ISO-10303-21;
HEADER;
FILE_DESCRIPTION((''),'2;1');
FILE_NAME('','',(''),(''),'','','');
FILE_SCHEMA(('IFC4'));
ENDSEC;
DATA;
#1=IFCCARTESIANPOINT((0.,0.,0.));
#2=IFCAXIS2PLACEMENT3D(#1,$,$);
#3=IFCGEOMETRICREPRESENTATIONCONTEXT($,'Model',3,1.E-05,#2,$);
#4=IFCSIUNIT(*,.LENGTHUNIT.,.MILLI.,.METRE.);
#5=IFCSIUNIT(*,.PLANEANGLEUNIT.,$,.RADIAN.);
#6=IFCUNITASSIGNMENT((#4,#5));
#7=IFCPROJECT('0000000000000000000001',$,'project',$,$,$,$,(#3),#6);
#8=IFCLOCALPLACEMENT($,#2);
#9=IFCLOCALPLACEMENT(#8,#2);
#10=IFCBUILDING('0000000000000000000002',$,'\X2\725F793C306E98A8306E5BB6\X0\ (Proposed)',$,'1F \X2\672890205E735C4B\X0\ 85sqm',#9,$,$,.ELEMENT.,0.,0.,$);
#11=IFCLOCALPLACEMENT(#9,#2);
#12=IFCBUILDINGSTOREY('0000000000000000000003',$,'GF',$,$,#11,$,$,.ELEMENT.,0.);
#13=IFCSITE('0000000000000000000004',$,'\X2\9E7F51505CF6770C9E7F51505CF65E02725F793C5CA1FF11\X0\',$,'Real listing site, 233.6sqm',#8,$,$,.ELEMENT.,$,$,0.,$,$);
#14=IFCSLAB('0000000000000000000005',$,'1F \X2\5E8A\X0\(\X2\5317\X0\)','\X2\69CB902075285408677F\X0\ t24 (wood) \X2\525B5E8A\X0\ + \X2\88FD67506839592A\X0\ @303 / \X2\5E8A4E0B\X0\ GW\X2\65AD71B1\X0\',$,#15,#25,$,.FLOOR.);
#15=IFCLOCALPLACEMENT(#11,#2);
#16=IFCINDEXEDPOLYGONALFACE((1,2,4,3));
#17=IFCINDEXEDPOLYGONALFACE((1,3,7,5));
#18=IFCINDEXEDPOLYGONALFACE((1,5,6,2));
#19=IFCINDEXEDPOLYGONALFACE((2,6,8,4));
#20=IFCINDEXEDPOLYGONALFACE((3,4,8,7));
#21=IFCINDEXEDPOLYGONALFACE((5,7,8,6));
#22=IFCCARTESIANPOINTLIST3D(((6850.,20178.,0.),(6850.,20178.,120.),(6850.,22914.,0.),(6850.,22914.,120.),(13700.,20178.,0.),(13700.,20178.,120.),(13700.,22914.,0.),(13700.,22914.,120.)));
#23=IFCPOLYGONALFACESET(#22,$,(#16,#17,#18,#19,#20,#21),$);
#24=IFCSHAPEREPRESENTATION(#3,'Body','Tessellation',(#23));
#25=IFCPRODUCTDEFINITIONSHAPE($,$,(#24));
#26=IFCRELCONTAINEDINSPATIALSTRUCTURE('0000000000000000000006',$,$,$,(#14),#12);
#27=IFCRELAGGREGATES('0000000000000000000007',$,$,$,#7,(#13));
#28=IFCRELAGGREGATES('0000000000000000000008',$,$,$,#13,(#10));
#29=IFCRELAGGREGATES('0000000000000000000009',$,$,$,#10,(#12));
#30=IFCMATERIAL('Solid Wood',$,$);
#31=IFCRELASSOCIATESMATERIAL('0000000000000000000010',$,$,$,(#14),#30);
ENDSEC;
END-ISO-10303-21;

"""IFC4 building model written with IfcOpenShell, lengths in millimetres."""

from ifc_helpers import new_model, si_unit, frame, frame_2d, origin, place, context, project, spatial, rectangle, extrude, material, element, save


model = new_model("IFC4")

# Units and contexts
model_context = context("Model", 3, precision=1e-05, world=origin())
ifc_project = project(units=[si_unit("LENGTHUNIT", "METRE", prefix="MILLI"), si_unit("PLANEANGLEUNIT", "RADIAN")], contexts=[model_context])

# Site, building, storey
site_placement = place(None, origin())
site = spatial("IfcSite", under=ifc_project, at=site_placement, Name="鹿児島県鹿児島市牟礼岡１", ObjectType="Real listing site, 233.6sqm", CompositionType="ELEMENT", RefElevation=0.0)
building_placement = place(site_placement, origin())
building = spatial("IfcBuilding", under=site, at=building_placement, Name="牟礼の風の家 (Proposed)", ObjectType="1F 木造平屋 85sqm", CompositionType="ELEMENT", ElevationOfRefHeight=0.0, ElevationOfTerrain=0.0)
storey_placement = place(building_placement, origin())
storey = spatial("IfcBuildingStorey", under=building, at=storey_placement, Name="GF", CompositionType="ELEMENT", Elevation=0.0)

# Slab
ifc_material_1 = material(Name="Solid Wood")
slab_1_placement = place(storey_placement, frame((3425.0, 10089.0, 0.0)))
element("IfcSlab", 1, at=slab_1_placement, inside=storey, material=ifc_material_1, Name="1F 床(北)", Description="構造用合板 t24 (wood) 剛床 + 製材根太 @303 / 床下 GW断熱", PredefinedType="FLOOR", context=model_context, shape_type="SweptSolid", body=[
    extrude(rectangle(XDim=6850.0, YDim=2736.0, at=frame_2d((3425.0, 1368.0))), frame((3425.0, 10089.0, 0.0)), (0.0, 0.0, 1.0), 120.0),
])

save(model, "model.ifc")
